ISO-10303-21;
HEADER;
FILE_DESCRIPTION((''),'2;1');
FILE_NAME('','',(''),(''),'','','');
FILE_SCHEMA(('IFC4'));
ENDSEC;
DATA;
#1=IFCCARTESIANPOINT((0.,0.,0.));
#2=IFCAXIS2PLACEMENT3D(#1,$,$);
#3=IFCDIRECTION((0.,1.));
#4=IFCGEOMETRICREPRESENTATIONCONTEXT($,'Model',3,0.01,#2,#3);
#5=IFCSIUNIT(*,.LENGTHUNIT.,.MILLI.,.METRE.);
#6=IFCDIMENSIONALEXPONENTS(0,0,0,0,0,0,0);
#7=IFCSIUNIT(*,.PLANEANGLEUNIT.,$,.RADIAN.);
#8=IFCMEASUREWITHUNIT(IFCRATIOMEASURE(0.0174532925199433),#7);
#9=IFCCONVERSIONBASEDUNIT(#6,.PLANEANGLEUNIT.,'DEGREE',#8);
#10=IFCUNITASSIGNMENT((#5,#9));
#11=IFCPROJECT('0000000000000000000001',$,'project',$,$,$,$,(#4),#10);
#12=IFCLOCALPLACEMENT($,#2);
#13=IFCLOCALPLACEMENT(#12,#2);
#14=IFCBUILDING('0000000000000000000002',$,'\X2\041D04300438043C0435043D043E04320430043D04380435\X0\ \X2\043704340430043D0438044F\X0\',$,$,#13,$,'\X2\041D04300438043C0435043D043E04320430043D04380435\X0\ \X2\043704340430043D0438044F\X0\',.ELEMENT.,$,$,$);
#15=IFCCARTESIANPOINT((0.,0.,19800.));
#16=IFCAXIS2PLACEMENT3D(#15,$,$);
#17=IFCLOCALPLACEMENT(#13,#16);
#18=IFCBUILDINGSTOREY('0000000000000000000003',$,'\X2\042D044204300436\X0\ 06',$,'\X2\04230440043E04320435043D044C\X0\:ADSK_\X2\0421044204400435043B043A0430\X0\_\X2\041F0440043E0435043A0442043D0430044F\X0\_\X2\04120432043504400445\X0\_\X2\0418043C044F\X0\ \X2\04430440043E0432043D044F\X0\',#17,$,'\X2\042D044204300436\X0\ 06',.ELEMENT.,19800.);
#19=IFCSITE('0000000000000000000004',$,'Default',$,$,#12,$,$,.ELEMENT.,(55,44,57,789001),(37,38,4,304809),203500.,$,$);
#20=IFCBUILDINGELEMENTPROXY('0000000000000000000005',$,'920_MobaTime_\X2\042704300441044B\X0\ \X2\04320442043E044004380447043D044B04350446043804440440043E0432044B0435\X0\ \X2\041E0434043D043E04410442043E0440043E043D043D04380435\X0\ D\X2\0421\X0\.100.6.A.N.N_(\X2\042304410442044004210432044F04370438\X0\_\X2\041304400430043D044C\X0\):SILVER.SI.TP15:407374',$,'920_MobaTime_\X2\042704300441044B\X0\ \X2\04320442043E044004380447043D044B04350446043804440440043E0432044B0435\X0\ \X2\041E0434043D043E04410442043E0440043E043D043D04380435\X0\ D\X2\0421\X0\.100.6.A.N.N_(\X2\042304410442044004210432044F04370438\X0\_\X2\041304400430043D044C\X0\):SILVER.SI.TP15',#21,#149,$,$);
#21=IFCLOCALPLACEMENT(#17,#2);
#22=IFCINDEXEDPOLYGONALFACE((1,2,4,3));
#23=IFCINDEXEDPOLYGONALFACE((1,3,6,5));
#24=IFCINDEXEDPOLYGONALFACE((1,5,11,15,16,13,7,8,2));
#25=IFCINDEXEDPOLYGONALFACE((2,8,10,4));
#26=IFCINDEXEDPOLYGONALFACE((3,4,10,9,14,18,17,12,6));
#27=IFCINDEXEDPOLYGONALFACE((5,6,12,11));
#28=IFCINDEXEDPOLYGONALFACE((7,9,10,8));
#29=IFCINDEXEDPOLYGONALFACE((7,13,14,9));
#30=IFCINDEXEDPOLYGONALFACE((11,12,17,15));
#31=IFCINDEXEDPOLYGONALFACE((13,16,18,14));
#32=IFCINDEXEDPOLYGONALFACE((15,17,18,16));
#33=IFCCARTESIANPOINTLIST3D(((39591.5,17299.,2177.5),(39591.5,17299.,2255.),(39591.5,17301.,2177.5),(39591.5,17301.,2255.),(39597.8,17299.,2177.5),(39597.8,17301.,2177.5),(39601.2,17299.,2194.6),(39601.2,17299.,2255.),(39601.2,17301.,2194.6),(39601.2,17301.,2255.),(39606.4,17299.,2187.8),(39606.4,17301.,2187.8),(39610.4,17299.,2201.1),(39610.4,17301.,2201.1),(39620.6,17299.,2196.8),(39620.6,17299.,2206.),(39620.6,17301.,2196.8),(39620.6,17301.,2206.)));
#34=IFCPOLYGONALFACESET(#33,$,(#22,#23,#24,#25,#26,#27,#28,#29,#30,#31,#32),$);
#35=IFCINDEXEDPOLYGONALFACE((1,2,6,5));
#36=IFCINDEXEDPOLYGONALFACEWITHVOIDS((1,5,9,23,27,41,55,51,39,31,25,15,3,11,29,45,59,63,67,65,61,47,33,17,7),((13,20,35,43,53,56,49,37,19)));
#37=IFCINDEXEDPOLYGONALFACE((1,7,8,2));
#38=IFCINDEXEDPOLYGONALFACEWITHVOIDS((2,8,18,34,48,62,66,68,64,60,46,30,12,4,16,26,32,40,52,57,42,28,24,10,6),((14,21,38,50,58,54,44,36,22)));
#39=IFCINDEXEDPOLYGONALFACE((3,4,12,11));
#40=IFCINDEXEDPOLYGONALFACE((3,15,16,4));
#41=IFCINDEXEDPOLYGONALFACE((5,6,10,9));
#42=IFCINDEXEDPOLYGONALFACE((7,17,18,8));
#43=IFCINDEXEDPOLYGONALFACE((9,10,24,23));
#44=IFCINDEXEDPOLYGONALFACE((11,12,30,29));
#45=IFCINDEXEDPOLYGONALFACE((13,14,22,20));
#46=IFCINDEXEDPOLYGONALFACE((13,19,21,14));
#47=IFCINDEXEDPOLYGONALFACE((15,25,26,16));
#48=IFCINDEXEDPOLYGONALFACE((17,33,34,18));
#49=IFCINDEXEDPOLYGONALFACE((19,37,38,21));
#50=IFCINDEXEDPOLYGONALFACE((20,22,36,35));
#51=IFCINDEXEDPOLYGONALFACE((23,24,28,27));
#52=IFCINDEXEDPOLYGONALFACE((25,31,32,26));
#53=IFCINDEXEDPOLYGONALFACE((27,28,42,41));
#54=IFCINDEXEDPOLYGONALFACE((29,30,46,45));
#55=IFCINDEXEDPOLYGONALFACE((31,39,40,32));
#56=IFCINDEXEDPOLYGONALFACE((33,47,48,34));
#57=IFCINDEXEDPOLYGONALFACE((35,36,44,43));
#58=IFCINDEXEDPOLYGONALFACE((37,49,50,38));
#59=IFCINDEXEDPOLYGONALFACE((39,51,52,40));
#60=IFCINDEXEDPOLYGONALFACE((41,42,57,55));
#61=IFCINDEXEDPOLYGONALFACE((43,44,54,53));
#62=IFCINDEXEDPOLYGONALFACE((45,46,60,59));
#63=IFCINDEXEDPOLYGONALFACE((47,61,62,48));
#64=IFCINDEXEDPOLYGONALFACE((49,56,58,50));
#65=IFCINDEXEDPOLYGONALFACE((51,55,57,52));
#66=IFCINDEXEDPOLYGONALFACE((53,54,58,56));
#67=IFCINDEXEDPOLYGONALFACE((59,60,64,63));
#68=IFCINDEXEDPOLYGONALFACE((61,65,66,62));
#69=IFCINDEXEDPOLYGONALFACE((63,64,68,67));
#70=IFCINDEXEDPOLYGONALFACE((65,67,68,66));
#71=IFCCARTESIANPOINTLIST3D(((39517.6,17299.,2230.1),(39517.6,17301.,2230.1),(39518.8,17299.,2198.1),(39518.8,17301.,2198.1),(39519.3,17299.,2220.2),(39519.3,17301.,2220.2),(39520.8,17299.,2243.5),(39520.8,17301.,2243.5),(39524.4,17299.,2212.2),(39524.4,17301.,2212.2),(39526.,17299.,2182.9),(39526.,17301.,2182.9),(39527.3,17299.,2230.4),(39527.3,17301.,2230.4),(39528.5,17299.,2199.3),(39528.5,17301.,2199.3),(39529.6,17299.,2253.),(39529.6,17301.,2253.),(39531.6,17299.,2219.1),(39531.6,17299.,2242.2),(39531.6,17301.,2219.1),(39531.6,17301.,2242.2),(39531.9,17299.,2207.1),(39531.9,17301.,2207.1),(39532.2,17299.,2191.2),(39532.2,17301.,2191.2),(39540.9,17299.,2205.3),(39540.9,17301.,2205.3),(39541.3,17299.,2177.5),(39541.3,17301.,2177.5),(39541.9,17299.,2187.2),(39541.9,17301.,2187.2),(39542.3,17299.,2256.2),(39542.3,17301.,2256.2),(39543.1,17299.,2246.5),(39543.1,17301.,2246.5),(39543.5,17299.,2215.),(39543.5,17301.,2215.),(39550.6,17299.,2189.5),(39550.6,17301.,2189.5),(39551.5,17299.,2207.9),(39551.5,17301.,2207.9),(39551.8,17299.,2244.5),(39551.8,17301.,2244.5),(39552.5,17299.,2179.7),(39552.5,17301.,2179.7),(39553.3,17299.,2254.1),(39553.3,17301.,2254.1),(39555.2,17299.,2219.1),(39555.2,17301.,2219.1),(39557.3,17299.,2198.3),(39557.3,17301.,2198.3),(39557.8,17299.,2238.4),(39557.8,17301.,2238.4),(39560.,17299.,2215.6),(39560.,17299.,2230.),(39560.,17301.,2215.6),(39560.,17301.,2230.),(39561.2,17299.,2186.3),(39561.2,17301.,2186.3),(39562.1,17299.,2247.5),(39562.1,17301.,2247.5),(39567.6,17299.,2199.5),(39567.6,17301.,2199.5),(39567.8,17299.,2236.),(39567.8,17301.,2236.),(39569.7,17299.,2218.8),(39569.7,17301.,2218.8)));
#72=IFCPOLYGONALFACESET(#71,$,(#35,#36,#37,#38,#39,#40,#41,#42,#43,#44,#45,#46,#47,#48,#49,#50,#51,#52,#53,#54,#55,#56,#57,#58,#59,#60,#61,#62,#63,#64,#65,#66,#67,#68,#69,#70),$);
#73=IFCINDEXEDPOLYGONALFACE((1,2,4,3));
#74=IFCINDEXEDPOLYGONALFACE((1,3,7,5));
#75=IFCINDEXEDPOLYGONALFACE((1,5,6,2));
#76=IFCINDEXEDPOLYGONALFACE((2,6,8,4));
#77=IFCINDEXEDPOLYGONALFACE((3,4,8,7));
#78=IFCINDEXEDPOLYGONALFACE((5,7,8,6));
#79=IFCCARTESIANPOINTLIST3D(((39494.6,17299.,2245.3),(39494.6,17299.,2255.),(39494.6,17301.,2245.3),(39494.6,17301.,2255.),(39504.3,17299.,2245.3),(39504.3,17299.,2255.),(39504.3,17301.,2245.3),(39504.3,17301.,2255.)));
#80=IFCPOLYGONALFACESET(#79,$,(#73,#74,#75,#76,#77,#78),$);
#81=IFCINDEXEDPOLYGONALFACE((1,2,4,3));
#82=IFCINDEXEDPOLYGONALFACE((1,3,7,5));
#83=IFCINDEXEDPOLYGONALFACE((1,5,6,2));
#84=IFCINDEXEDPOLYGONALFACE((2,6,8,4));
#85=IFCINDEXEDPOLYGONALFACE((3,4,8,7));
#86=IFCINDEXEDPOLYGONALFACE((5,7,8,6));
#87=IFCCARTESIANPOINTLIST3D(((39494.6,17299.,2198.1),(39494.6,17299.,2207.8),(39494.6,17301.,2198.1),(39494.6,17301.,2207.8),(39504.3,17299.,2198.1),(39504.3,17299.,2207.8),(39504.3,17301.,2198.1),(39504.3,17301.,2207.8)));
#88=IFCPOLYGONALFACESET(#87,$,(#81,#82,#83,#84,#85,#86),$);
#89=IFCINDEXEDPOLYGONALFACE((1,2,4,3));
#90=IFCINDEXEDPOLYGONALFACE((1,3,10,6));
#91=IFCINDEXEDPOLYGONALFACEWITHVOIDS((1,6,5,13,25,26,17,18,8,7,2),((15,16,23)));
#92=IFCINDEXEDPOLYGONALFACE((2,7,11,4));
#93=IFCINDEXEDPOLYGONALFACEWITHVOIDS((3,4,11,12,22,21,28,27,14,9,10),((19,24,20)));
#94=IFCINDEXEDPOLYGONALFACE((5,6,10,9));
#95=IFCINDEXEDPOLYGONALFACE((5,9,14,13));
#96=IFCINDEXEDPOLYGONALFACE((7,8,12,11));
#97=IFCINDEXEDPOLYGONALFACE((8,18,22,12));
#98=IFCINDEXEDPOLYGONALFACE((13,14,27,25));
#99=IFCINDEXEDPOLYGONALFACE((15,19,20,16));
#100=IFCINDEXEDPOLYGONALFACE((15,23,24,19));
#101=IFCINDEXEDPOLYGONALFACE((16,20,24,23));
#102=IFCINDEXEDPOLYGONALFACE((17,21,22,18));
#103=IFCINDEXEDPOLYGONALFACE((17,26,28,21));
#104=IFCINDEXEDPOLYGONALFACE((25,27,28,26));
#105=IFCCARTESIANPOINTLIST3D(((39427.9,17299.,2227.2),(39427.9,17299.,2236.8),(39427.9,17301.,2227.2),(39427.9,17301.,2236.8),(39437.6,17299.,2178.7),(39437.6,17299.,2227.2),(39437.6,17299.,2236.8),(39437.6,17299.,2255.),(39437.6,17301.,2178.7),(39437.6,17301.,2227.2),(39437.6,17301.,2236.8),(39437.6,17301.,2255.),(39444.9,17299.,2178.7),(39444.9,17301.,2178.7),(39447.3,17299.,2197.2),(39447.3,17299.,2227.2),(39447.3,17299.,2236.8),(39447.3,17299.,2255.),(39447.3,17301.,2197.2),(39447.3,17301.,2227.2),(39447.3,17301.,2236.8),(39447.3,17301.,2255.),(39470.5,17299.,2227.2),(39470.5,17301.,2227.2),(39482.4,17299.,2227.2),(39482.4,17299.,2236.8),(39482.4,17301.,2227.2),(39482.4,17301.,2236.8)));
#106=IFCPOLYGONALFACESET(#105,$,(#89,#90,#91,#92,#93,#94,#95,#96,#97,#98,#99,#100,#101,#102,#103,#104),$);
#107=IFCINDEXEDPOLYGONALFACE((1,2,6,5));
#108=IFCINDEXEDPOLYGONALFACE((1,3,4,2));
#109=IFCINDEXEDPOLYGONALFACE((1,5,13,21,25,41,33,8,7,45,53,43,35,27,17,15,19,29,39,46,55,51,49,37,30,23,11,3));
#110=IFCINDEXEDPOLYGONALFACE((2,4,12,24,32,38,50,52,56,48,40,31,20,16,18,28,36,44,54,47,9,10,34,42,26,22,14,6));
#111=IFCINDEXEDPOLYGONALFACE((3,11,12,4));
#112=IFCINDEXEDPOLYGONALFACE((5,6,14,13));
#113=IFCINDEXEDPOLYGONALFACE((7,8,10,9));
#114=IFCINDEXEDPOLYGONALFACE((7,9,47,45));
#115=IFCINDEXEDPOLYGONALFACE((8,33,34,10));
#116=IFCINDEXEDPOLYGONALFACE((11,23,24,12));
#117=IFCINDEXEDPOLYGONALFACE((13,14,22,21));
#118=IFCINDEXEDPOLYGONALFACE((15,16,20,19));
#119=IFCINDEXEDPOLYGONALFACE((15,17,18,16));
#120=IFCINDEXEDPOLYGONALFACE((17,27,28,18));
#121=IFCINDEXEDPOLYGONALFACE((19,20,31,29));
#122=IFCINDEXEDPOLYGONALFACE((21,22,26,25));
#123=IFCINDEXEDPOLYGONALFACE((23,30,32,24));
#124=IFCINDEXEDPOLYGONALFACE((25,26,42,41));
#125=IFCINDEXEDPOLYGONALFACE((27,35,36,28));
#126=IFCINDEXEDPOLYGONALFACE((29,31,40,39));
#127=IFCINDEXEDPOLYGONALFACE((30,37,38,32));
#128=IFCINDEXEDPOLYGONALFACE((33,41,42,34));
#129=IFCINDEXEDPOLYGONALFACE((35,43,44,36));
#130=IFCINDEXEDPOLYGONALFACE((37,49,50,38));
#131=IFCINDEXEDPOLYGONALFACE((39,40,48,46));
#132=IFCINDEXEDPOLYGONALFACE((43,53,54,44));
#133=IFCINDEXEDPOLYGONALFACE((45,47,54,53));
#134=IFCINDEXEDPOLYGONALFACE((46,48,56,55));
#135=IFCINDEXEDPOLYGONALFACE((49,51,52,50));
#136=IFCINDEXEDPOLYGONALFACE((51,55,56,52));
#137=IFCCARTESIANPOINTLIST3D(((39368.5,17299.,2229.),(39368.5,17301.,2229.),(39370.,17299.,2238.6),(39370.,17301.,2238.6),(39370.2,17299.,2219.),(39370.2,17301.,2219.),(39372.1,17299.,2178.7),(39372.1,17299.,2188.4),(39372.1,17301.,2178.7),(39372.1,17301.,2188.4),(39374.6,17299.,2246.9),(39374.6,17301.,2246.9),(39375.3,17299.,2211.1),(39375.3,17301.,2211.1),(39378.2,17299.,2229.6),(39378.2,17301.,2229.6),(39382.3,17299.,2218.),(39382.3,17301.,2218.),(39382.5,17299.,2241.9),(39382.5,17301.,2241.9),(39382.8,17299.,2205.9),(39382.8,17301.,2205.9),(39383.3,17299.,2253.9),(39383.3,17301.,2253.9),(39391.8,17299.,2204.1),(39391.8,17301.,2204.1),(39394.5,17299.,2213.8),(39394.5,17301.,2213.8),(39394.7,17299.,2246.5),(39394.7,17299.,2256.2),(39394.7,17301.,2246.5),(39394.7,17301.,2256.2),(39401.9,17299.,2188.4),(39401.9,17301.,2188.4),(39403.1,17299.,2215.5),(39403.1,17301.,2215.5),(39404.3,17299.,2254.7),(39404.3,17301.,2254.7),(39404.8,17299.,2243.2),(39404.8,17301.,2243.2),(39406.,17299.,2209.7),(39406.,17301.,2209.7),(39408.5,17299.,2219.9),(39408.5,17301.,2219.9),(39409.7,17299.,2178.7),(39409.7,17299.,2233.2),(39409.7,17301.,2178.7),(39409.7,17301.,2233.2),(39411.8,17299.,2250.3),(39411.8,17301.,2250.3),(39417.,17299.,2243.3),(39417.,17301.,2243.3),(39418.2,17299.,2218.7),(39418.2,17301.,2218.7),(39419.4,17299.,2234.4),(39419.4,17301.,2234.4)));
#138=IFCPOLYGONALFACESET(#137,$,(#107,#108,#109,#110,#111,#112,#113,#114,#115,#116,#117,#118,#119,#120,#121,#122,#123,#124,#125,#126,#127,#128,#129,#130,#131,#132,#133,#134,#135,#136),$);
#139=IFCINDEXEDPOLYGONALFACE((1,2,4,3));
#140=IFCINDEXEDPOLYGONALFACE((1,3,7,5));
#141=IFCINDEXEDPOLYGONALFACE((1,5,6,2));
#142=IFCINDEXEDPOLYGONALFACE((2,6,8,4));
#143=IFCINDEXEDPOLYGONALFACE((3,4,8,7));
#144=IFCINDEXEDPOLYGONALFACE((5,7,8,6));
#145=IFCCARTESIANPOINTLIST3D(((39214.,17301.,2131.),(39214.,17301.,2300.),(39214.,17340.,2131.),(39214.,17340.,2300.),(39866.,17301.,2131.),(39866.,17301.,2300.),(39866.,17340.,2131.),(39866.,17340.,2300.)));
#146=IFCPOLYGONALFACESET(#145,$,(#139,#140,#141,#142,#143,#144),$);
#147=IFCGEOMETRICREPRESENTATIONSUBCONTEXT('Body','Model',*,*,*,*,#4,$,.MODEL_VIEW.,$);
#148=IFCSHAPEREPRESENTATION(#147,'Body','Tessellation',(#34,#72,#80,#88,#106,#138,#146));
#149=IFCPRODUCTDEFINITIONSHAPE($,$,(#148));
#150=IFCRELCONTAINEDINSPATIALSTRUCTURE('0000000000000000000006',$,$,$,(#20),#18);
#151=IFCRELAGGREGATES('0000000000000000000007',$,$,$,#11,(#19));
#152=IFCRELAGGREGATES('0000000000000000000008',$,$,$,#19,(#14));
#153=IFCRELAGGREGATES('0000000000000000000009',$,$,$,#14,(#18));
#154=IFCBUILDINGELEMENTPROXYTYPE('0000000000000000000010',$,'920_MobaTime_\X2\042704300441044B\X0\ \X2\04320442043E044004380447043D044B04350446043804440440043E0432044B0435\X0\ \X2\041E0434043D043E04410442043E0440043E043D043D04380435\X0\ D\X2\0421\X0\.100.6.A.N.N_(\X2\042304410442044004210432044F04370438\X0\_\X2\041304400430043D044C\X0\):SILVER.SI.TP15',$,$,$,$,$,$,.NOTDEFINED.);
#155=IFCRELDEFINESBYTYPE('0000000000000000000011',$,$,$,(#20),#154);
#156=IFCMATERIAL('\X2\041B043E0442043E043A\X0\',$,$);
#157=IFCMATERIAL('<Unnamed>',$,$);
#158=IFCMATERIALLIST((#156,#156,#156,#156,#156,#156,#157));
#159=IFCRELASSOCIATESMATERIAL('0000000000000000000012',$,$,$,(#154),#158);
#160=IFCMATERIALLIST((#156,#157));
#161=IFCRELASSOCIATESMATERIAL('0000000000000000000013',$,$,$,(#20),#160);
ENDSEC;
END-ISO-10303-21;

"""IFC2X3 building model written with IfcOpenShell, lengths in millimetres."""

from ifc_helpers import new_model, entity, si_unit, converted_unit, direction, frame, origin, origin_2d_with_axis, place, context, subcontext, project, spatial, polyline, rectangle, outline, extrude, source, transform, mapped, material, material_list, type_object, type_shapes, element, save


model = new_model("IFC2X3")

# Units and contexts
model_context = context("Model", 3, precision=0.01, world=origin(), true_north=direction((0.0, 1.0)))
body_context = subcontext(model_context, "Body", "Model", "MODEL_VIEW")
ifc_project = project(units=[si_unit("LENGTHUNIT", "METRE", prefix="MILLI"), converted_unit("PLANEANGLEUNIT", "DEGREE", entity("IfcRatioMeasure", 0.0174532925199433), si_unit("PLANEANGLEUNIT", "RADIAN"), dimensions=[0, 0, 0, 0, 0, 0, 0])], contexts=[model_context])

# Site, building, storey
site_placement = place(None, frame((0.0, 0.0, 0.0)))
site = spatial("IfcSite", under=ifc_project, at=site_placement, Name="Default", CompositionType="ELEMENT", RefLatitude=(55, 44, 57, 789001), RefLongitude=(37, 38, 4, 304809), RefElevation=203500.0)
building_placement = place(site_placement, origin())
building = spatial("IfcBuilding", under=site, at=building_placement, Name="Наименование здания", LongName="Наименование здания", CompositionType="ELEMENT")
storey_placement = place(building_placement, frame((0.0, 0.0, 19800.0)))
storey = spatial("IfcBuildingStorey", under=building, at=storey_placement, Name="Этаж 06", ObjectType="Уровень:ADSK_Стрелка_Проектная_Вверх_Имя уровня", LongName="Этаж 06", CompositionType="ELEMENT", Elevation=19800.0)

# Building element proxy
ifc_material_1 = material(Name="Лоток")
ifc_material_2 = material(Name="<Unnamed>")
ifc_material_list_1 = material_list([ifc_material_1, ifc_material_1, ifc_material_1, ifc_material_1, ifc_material_1, ifc_material_1, ifc_material_2])
building_element_proxy_type_1 = type_object("IfcBuildingElementProxyType", Name="920_MobaTime_Часы вторичныецифровые Односторонние DС.100.6.A.N.N_(УстрСвязи_Грань):SILVER.SI.TP15", PredefinedType="NOTDEFINED", material=ifc_material_list_1)
shared_shape_1 = source(origin(), body_context, "Body", "SweptSolid", [
    extrude(outline(polyline([(-49.3, -13.1), (28.2, -13.1), (28.2, -6.8), (17.9, 1.8), (8.9, 16.0), (-0.3, 16.0), (4.6, 5.8), (11.1, -3.4), (-49.3, -3.4), (-49.3, -13.1)])), frame((-64.6, 9.8, 39.0), z_axis=(0.0, 0.0, 1.0), x_axis=(0.0, 1.0, 0.0)), (0.0, 0.0, 1.0), 2.0),
    extrude(outline(polyline([(2.2, -27.6), (19.0, -27.6), (30.5, -16.1), (33.3, -4.9), (31.0, 5.8), (21.8, 17.2), (5.2, 27.3), (-11.1, 33.0), (-24.0, 32.7), (-33.6, 27.6), (-40.3, 18.6), (-42.8, 5.7), (-38.0, -6.3), (-27.2, -15.0), (-17.5, -17.7), (-8.2, -16.4), (-0.3, -11.9), (5.1, -4.5), (7.3, 6.2), (4.0, 17.2), (18.5, 7.3), (23.6, -2.4), (22.0, -11.4), (14.2, -18.4), (5.3, -18.3), (2.2, -27.6)]), holes=[polyline([(-9.0, 23.3), (-1.3, 14.4), (-2.6, 2.0), (-11.4, -7.0), (-23.4, -6.1), (-32.2, 2.9), (-31.2, 15.1), (-25.6, 22.1), (-17.5, 24.9), (-9.0, 23.3)])]), frame((-2.7, 3.6, 39.0), z_axis=(0.0, 0.0, 1.0), x_axis=(-0.427649, 0.903945, 0.0)), (0.0, 0.0, 1.0), 2.0),
    extrude(rectangle(XDim=9.7, YDim=9.7, at=origin_2d_with_axis()), frame((40.6, -34.7, 39.0)), (0.0, 0.0, 1.0), 2.0),
    extrude(rectangle(XDim=9.7, YDim=9.7, at=origin_2d_with_axis()), frame((40.6, 12.6, 39.0)), (0.0, 0.0, 1.0), 2.0),
    extrude(outline(polyline([(-0.9, -28.1), (8.8, -28.1), (8.8, -9.9), (18.5, -9.9), (18.5, -0.2), (8.8, -0.2), (8.8, 48.3), (1.5, 48.3), (-36.0, -0.2), (-36.0, -9.9), (-0.9, -9.9), (-0.9, -28.1)]), holes=[polyline([(-0.9, -0.2), (-24.1, -0.2), (-0.9, 29.7), (-0.9, -0.2)])]), frame((93.6, -11.4, 39.0)), (0.0, 0.0, 1.0), 2.0),
    extrude(outline(polyline([(3.3, -28.3), (12.5, -28.3), (20.5, -25.0), (26.8, -18.8), (30.7, -10.0), (31.4, 1.6), (26.9, 11.8), (20.1, 18.4), (11.1, 22.3), (1.0, 23.3), (-7.9, 20.4), (-14.9, 14.5), (-18.9, 6.2), (-17.1, -9.0), (-36.7, 0.5), (-29.1, 29.3), (-38.5, 31.7), (-48.1, -4.6), (-11.6, -23.0), (-8.0, -14.0), (-10.8, -7.6), (-10.2, 1.1), (-3.0, 11.8), (9.2, 12.8), (20.0, 5.4), (21.3, -7.5), (15.5, -16.4), (4.6, -18.6), (3.3, -28.3)])), frame((147.1, -8.5, 39.0), z_axis=(0.0, 0.0, 1.0), x_axis=(0.256974, -0.966418, 0.0)), (0.0, 0.0, 1.0), 2.0),
    extrude(rectangle(XDim=652.0, YDim=169.0, at=origin_2d_with_axis()), frame((0.0, 0.0, 0.0), z_axis=(0.0, 0.0, 1.0), x_axis=(-1.0, 0.0, 0.0)), (0.0, 0.0, 1.0), 39.0),
])
type_shapes(building_element_proxy_type_1, [shared_shape_1])
ifc_material_list_2 = material_list([ifc_material_1, ifc_material_2])
proxy_1_placement = place(storey_placement, frame((39540.0, 17340.0, 2215.5), z_axis=(0.0, -1.0, 0.0), x_axis=(-1.0, 0.0, 0.0)))
element("IfcBuildingElementProxy", 1, at=proxy_1_placement, inside=storey, type_object=building_element_proxy_type_1, material=ifc_material_list_2, Name="920_MobaTime_Часы вторичныецифровые Односторонние DС.100.6.A.N.N_(УстрСвязи_Грань):SILVER.SI.TP15:407374", ObjectType="920_MobaTime_Часы вторичныецифровые Односторонние DС.100.6.A.N.N_(УстрСвязи_Грань):SILVER.SI.TP15", context=body_context, shape_type="MappedRepresentation", body=[
    mapped(shared_shape_1, transform((0.0, 0.0, 0.0), scale=1.0)),
])

save(model, "model.ifc")
